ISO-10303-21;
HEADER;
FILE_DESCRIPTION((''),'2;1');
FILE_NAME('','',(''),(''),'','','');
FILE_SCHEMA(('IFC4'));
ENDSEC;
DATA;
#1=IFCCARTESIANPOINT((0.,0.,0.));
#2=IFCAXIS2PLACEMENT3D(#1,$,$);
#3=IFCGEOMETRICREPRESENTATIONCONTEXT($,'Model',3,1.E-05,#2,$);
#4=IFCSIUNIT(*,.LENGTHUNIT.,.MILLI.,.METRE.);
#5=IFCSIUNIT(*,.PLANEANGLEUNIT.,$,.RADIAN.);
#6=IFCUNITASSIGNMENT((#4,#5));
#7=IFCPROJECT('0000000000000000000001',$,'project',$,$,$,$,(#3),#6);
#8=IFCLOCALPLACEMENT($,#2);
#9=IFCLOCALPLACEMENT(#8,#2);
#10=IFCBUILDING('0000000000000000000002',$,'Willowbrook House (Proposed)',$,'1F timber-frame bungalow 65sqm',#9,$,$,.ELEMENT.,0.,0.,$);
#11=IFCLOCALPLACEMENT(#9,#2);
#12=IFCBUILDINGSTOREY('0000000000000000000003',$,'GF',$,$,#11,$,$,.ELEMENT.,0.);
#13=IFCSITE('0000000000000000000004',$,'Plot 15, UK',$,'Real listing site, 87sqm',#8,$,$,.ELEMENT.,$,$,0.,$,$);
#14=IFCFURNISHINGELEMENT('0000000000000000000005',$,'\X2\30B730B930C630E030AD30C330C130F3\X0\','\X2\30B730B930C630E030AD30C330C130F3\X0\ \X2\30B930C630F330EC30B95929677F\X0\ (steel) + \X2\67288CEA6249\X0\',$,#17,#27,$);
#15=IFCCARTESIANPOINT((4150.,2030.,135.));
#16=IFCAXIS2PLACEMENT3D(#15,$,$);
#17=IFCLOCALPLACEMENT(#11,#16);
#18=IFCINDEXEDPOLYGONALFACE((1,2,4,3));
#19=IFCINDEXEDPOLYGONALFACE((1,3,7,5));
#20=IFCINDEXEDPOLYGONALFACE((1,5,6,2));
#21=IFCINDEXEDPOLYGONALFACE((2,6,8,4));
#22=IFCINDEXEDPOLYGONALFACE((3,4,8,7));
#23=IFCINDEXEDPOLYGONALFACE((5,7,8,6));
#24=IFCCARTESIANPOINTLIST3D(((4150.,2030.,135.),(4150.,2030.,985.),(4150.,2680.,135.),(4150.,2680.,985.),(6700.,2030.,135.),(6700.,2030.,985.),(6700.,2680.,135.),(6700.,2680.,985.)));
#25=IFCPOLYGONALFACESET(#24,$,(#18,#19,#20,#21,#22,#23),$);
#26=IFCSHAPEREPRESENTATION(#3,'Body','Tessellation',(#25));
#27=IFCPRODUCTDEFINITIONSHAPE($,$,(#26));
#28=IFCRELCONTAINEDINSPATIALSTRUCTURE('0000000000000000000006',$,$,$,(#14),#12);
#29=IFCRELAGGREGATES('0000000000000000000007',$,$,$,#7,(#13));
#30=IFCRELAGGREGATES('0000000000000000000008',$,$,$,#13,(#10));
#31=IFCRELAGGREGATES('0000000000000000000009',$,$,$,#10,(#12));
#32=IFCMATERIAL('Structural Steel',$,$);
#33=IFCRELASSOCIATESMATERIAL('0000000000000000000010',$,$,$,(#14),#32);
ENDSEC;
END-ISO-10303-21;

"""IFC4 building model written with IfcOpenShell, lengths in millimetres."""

from ifc_helpers import new_model, si_unit, frame, frame_2d, origin, place, context, project, spatial, rectangle, extrude, material, element, save


model = new_model("IFC4")

# Units and contexts
model_context = context("Model", 3, precision=1e-05, world=origin())
ifc_project = project(units=[si_unit("LENGTHUNIT", "METRE", prefix="MILLI"), si_unit("PLANEANGLEUNIT", "RADIAN")], contexts=[model_context])

# Site, building, storey
site_placement = place(None, origin())
site = spatial("IfcSite", under=ifc_project, at=site_placement, Name="Plot 15, UK", ObjectType="Real listing site, 87sqm", CompositionType="ELEMENT", RefElevation=0.0)
building_placement = place(site_placement, origin())
building = spatial("IfcBuilding", under=site, at=building_placement, Name="Willowbrook House (Proposed)", ObjectType="1F timber-frame bungalow 65sqm", CompositionType="ELEMENT", ElevationOfRefHeight=0.0, ElevationOfTerrain=0.0)
storey_placement = place(building_placement, origin())
storey = spatial("IfcBuildingStorey", under=building, at=storey_placement, Name="GF", CompositionType="ELEMENT", Elevation=0.0)

# Furnishing element
ifc_material_1 = material(Name="Structural Steel")
furnishing_1_placement = place(storey_placement, frame((4150.0, 2030.0, 135.0)))
element("IfcFurnishingElement", 1, at=furnishing_1_placement, inside=storey, material=ifc_material_1, Name="システムキッチン", Description="システムキッチン ステンレス天板 (steel) + 木質扉", context=model_context, shape_type="SweptSolid", body=[
    extrude(rectangle(XDim=2550.0, YDim=650.0, at=frame_2d((1275.0, 325.0))), frame((4150.0, 2030.0, 135.0)), (0.0, 0.0, 1.0), 850.0),
])

save(model, "model.ifc")
